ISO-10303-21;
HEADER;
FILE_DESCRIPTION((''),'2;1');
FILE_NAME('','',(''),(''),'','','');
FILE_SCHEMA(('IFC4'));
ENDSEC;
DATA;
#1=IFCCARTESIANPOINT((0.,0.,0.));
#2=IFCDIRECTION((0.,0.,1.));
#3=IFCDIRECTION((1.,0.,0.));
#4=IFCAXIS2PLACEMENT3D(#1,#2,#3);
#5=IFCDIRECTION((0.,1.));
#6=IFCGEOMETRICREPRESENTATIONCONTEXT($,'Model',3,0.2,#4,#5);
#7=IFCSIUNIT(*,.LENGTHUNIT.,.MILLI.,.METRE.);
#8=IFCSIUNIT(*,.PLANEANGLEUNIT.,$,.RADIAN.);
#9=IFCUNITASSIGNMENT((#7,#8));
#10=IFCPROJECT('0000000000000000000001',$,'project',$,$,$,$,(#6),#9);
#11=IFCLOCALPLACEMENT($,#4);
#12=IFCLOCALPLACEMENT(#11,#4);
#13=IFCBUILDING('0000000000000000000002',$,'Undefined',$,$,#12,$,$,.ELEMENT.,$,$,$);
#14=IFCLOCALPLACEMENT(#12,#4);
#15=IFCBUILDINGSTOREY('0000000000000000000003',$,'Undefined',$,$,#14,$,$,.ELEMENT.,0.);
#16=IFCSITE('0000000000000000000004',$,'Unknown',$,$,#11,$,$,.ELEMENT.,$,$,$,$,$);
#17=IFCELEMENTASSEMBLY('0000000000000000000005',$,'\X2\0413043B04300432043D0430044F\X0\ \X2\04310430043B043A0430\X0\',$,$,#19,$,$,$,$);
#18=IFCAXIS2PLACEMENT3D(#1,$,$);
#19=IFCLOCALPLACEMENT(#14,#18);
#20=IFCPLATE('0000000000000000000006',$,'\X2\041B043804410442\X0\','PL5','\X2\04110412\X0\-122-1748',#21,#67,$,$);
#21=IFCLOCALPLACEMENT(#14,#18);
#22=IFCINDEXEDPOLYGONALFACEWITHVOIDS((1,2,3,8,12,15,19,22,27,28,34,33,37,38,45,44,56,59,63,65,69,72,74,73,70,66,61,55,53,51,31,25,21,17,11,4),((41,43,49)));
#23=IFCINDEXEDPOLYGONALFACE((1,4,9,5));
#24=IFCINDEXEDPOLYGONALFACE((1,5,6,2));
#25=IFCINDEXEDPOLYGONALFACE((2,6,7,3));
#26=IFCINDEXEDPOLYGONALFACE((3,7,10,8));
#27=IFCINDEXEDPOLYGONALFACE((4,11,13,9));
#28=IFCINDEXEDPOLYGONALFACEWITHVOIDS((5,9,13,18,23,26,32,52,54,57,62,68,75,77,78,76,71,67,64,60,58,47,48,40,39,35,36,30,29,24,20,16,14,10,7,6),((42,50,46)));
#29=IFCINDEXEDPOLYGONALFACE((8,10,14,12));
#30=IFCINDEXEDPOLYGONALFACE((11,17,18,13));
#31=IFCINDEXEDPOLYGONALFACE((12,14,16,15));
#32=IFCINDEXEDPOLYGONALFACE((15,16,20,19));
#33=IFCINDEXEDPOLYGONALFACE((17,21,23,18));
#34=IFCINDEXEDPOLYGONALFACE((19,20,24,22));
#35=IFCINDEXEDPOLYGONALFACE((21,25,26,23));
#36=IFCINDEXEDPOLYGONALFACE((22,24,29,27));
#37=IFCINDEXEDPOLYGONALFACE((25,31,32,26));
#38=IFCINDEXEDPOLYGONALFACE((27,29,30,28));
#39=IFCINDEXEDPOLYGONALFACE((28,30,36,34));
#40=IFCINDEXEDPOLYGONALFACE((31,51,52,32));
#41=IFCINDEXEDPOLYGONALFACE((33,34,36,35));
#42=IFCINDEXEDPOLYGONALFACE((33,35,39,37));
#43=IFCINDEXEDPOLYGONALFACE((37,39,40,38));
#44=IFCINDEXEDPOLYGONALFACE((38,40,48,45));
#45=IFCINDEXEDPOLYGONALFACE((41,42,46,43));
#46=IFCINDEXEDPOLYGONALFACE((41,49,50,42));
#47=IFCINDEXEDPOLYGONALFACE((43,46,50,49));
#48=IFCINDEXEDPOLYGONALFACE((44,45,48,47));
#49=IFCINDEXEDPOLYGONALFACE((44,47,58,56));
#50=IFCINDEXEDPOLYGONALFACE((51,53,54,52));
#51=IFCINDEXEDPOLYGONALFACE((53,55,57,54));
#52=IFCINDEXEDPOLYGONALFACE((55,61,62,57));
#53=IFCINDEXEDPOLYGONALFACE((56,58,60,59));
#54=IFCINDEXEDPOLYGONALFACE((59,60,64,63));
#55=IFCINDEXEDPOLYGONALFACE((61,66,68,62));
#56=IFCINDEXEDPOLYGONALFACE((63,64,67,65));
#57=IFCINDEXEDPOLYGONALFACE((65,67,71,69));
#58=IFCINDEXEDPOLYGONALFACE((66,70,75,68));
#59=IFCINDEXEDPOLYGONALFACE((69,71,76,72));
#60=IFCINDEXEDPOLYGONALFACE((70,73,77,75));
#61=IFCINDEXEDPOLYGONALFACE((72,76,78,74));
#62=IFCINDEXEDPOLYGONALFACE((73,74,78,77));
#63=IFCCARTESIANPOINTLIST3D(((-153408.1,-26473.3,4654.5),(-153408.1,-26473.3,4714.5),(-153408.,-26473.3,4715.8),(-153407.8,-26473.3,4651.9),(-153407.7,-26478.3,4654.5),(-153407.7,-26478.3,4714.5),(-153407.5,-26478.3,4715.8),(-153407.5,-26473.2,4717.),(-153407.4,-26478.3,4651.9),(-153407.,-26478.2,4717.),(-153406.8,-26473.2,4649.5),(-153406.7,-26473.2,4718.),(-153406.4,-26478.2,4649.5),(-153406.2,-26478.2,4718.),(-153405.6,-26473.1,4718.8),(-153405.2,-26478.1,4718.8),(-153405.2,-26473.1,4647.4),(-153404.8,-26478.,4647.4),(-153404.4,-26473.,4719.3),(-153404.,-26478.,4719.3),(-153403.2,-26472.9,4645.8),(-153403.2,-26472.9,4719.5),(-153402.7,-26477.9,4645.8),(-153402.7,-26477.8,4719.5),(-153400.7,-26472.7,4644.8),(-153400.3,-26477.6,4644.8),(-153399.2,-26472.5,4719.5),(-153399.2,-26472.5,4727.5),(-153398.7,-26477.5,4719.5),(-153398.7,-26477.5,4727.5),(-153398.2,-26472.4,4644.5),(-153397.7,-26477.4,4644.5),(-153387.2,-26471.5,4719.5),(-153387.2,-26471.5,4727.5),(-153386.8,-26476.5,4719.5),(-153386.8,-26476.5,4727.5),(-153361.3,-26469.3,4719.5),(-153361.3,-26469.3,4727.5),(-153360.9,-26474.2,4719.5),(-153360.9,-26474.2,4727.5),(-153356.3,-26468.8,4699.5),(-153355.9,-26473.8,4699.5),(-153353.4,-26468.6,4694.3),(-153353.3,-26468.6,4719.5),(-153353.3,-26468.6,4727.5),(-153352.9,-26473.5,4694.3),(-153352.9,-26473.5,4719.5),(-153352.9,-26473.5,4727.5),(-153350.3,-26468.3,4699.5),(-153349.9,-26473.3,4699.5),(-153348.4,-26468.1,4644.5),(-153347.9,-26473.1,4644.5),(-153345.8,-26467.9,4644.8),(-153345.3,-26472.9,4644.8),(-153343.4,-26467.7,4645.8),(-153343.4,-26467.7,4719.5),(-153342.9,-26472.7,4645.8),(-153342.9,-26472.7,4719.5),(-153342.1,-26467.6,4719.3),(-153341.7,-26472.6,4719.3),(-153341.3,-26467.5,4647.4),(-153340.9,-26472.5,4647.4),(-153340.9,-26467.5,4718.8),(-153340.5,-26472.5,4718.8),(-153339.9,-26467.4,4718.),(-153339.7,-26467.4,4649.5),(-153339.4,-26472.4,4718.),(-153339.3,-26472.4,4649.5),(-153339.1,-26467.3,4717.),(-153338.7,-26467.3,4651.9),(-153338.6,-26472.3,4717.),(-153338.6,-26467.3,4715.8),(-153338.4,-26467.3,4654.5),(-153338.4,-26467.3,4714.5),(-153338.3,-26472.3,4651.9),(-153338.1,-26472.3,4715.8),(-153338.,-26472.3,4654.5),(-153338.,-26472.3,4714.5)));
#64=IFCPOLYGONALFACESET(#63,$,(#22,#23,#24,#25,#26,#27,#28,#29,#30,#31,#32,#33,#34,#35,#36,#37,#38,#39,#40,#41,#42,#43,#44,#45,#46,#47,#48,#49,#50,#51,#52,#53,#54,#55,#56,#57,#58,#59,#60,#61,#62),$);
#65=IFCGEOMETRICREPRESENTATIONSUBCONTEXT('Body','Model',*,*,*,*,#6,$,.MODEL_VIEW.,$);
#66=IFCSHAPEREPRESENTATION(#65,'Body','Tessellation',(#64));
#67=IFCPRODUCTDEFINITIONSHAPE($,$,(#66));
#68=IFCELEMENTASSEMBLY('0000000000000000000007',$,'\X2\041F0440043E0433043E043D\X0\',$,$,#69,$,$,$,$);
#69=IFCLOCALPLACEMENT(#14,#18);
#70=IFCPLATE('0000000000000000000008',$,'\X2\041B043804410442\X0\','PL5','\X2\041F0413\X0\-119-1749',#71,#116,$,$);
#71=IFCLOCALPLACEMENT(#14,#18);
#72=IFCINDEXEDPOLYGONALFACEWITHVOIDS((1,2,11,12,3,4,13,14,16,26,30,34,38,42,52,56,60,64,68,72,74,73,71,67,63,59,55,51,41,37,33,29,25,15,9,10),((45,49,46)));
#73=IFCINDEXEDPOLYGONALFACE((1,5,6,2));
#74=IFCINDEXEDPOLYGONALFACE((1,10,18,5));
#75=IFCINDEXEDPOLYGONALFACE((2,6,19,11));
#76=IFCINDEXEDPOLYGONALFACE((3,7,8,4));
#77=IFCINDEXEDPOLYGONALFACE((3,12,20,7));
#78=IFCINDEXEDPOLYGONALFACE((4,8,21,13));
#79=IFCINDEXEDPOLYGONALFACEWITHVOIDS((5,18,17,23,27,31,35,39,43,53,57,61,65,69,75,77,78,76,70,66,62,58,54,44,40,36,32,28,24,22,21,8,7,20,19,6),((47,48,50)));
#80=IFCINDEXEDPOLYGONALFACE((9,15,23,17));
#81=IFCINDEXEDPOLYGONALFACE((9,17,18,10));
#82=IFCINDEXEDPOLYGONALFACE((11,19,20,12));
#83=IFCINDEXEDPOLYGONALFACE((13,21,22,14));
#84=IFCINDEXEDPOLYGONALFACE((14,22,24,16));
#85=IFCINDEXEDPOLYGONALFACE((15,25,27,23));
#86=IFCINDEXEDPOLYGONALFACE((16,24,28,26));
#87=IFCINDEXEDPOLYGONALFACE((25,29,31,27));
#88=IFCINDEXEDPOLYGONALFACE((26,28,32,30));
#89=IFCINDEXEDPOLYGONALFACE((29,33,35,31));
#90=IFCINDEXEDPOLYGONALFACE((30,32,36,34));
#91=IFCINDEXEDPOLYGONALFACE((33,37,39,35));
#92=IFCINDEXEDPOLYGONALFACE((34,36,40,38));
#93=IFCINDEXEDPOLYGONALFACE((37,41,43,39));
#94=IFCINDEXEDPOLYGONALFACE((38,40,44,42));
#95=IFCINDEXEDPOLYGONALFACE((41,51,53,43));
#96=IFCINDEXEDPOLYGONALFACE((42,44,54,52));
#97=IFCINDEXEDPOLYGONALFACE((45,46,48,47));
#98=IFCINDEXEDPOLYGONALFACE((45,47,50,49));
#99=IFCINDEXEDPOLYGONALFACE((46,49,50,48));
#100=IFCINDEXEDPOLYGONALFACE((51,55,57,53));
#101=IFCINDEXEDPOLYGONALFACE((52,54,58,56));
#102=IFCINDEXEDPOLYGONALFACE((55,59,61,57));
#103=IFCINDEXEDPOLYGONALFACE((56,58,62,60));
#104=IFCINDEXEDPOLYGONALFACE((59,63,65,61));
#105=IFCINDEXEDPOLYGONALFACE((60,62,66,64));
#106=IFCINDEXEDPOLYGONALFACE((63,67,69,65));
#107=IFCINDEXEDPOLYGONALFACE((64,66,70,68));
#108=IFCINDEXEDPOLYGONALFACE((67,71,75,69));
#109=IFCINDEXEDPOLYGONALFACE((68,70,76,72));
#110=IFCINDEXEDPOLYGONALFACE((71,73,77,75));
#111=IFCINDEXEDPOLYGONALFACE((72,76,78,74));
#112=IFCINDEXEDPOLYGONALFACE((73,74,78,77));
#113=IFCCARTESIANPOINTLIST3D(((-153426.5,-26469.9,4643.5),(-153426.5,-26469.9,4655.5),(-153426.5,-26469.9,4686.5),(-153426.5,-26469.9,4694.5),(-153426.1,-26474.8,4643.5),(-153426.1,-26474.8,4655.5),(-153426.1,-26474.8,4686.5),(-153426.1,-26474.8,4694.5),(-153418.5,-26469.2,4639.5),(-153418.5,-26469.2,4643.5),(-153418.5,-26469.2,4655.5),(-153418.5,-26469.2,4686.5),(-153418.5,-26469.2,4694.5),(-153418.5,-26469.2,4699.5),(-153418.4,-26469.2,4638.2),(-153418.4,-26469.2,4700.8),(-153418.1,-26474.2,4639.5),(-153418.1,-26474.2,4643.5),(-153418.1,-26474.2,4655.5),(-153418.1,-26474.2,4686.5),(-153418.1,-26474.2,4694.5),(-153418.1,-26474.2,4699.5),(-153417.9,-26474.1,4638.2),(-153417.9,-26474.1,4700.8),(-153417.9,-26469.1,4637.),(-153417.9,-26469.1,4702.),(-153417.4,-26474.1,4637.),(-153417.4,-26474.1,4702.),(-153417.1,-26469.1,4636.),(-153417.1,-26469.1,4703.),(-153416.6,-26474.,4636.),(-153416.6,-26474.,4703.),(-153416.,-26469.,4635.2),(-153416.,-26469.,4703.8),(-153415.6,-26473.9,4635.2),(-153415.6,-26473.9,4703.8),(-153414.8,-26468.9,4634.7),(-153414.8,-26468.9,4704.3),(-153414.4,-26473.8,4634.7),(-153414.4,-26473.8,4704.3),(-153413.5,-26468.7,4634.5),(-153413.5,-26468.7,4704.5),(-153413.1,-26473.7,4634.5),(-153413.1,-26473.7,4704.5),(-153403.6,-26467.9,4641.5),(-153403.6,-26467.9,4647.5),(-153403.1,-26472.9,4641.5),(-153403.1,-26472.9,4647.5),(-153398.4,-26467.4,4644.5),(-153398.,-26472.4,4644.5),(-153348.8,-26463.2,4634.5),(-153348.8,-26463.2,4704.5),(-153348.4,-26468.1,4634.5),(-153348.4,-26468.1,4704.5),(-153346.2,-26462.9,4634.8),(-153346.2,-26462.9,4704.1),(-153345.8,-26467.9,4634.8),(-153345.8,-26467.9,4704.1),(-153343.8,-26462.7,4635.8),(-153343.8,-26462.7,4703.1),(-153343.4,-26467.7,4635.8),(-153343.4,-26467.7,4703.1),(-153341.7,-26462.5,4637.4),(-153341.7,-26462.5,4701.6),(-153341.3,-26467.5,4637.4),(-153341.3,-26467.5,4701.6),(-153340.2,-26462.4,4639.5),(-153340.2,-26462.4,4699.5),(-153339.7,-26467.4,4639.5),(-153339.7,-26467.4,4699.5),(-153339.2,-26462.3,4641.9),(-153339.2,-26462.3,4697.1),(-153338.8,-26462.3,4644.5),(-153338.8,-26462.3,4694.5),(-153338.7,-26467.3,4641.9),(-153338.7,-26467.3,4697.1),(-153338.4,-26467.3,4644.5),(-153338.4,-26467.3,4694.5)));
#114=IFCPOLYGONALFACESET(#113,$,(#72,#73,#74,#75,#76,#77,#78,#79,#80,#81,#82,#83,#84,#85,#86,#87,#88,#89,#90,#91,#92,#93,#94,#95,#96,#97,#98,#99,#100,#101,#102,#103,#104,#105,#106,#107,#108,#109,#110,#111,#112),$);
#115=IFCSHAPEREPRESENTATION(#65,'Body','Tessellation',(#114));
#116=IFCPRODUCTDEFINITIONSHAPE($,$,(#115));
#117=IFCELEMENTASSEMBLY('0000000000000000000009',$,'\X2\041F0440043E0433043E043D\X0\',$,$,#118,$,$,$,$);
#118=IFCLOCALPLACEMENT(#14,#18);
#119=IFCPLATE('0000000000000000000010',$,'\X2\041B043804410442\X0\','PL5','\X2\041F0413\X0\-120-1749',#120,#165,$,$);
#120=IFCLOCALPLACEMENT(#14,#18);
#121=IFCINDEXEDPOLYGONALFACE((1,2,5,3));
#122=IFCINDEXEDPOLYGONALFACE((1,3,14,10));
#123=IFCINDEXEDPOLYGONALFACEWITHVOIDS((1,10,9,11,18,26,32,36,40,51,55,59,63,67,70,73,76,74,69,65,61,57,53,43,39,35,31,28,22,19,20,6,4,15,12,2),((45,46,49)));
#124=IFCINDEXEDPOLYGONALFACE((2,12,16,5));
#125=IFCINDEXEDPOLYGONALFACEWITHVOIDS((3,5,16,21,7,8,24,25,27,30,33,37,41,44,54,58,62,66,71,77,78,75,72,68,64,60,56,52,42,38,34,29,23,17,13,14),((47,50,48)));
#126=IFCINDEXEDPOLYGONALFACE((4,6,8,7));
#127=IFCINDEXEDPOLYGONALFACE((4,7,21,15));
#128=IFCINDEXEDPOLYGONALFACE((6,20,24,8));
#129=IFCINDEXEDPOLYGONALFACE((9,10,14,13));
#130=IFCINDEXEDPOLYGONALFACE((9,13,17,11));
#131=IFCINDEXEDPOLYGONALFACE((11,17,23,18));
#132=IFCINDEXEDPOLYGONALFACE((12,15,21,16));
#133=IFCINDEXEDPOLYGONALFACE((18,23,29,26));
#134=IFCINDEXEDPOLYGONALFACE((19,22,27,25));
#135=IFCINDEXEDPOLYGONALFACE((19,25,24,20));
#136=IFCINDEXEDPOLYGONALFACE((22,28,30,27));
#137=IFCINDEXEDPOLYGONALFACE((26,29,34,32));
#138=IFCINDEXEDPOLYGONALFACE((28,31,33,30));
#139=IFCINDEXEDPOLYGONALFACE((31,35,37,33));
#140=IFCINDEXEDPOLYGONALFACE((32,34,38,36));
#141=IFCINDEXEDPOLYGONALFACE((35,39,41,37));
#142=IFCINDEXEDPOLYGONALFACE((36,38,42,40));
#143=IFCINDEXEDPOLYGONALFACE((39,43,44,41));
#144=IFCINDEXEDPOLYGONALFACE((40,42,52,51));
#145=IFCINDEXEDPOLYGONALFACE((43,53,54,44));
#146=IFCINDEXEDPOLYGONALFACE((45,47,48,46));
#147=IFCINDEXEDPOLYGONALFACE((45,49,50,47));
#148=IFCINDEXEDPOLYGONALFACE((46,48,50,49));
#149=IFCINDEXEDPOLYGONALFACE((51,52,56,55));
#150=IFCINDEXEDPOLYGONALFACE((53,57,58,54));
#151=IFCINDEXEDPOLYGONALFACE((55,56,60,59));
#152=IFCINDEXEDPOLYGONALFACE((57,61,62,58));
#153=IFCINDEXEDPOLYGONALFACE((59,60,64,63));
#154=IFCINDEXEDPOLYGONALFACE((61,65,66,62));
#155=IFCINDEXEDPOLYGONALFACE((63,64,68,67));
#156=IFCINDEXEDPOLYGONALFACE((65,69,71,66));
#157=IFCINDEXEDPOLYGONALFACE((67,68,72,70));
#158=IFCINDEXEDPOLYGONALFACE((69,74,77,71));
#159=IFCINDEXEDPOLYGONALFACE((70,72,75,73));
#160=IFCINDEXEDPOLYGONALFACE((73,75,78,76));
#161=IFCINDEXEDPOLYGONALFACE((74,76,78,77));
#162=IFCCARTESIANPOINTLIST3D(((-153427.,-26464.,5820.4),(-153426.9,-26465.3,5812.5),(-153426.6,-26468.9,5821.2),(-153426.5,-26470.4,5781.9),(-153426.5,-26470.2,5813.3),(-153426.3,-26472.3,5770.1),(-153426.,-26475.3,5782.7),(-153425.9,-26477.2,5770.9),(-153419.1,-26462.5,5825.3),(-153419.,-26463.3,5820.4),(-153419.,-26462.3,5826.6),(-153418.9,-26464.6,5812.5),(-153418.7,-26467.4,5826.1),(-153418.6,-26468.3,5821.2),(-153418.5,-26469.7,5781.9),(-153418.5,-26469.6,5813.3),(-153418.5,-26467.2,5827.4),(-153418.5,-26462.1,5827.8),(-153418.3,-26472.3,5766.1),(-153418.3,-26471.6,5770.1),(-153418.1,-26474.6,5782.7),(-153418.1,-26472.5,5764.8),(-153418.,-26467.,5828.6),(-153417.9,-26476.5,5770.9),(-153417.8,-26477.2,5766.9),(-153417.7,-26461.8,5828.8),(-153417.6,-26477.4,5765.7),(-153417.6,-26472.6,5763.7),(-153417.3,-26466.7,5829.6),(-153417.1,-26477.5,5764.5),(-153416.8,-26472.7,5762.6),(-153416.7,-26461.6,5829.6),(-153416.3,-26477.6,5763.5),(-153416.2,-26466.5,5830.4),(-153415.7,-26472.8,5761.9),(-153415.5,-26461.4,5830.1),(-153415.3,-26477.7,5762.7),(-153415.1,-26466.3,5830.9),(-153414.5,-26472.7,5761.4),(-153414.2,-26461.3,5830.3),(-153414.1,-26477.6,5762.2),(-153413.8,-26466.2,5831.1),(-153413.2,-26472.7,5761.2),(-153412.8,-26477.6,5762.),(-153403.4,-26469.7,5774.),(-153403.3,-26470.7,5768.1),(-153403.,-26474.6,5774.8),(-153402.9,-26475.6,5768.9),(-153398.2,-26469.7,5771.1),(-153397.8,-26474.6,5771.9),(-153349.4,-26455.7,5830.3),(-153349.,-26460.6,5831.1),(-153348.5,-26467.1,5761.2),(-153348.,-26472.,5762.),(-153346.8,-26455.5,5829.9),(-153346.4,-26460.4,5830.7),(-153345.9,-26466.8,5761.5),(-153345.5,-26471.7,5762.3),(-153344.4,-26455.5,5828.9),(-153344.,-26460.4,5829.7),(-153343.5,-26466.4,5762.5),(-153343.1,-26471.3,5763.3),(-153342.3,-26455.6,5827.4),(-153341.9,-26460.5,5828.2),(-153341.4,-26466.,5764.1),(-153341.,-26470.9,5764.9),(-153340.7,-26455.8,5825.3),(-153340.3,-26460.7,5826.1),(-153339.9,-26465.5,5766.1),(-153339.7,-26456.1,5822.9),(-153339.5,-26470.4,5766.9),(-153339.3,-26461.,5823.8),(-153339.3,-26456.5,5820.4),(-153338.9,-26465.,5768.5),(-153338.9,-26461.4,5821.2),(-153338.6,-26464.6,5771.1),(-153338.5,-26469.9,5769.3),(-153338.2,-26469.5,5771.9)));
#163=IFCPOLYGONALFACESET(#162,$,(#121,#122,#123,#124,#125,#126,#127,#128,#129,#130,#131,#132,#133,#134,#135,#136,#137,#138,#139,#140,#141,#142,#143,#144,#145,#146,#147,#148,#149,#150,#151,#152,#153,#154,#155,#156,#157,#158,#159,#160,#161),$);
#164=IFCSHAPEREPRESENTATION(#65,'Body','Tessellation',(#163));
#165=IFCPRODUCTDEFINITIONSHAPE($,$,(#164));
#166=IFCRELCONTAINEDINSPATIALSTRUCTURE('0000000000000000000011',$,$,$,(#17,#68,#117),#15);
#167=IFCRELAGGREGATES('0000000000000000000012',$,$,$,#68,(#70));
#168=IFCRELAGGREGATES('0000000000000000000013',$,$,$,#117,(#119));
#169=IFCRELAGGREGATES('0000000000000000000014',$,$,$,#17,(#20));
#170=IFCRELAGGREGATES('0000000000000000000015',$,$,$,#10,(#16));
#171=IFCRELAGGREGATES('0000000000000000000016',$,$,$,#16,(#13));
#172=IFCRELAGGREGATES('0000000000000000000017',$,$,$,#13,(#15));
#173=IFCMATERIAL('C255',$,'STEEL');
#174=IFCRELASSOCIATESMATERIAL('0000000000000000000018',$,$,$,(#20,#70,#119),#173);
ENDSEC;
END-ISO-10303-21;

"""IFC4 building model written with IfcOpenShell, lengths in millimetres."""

from ifc_helpers import new_model, si_unit, direction, frame, origin_with_axes, place, context, subcontext, project, spatial, line, arc, indexed_curve, outline, extrude, material, element, aggregate, save


model = new_model("IFC4")

# Units and contexts
model_context = context("Model", 3, precision=0.2, world=origin_with_axes(), true_north=direction((0.0, 1.0)))
body_context = subcontext(model_context, "Body", "Model", "MODEL_VIEW")
ifc_project = project(units=[si_unit("LENGTHUNIT", "METRE", prefix="MILLI"), si_unit("PLANEANGLEUNIT", "RADIAN")], contexts=[model_context])

# Site, building, storey
site_placement = place(None, origin_with_axes())
site = spatial("IfcSite", under=ifc_project, at=site_placement, Name="Unknown", CompositionType="ELEMENT")
building_placement = place(site_placement, origin_with_axes())
building = spatial("IfcBuilding", under=site, at=building_placement, Name="Undefined", CompositionType="ELEMENT")
storey_placement = place(building_placement, origin_with_axes())
storey = spatial("IfcBuildingStorey", under=building, at=storey_placement, Name="Undefined", CompositionType="ELEMENT", Elevation=0.0)

# Shared definitions
ifc_material_1 = material(Name="C255", Category="STEEL")

# Element assembly, plate, voiding feature
assembly_1_placement = place(storey_placement, frame((-153222.7, -28270.2, 4779.5), z_axis=(-0.996286, -0.086101, -0.000024), x_axis=(-0.086101, 0.996286, 0.0)))
assembly_1 = element("IfcElementAssembly", 1, at=assembly_1_placement, inside=storey, Name="Главная балка")
plate_1_placement = place(assembly_1_placement, frame((1803.7, 135.0, -40.0), z_axis=(1.0, 0.000054, 0.000013), x_axis=(-0.000013, -0.000054, 1.0)))
plate_1 = element("IfcPlate", 2, at=plate_1_placement, material=ifc_material_1, Name="Лист", Description="PL5", ObjectType="БВ-122-1748", context=body_context, shape_type="SolidModel", body=[
    extrude(outline(indexed_curve([(0.0, 10.0), (2.9, 2.9), (10.0, 0.0), (60.0, 0.0), (67.1, 2.9), (70.0, 10.0), (70.0, 70.0), (68.5, 73.5), (65.0, 75.0), (61.0, 75.0), (61.0, 83.0), (49.0, 83.0), (49.0, 75.0), (23.0, 75.0), (23.0, 83.0), (15.0, 83.0), (15.0, 75.0), (5.0, 75.0), (1.5, 73.5), (0.0, 70.0)], segments=[arc(1, 2, 3), line(3, 4), arc(4, 5, 6), line(6, 7), arc(7, 8, 9), line(9, 10, 11, 12, 13, 14, 15, 16, 17, 18), arc(18, 19, 20), line(20, 1)])), frame((0.0, 0.0, 2.5), z_axis=(0.0, 0.0, 1.0), x_axis=(1.0, 0.0, 0.0)), (0.0, 0.0, -1.0), 5.0),
])
voiding_feature_1_placement = place(plate_1_placement, frame((15.0, 55.0, 10.0), z_axis=(0.007997, -0.999968, -0.000026), x_axis=(0.0, 0.000026, -1.0)))
element("IfcVoidingFeature", 3, at=voiding_feature_1_placement, cuts=plate_1, Name="Балка", ObjectType="(?)", PredefinedType="HOLE", context=body_context, shape_type="SolidModel", body=[
    extrude(outline(indexed_curve([(0.0, -3.0), (5.2, 0.0), (0.0, 3.0)], segments=[line(1, 2, 3, 1)])), frame((0.0, 0.0, 0.0), z_axis=(-1.0, 0.0, 0.0), x_axis=(0.0, 0.0, 1.0)), (0.0, 0.0, -1.0), 20.0),
])

# Element assembly, plate, voiding feature
assembly_2_placement = place(storey_placement, frame((-153458.2, -26475.1, 3063.5), z_axis=(0.086114, -0.996285, 0.0), x_axis=(0.0, 0.0, 1.0)))
assembly_2 = element("IfcElementAssembly", 4, at=assembly_2_placement, inside=storey, Name="Прогон")
plate_2_placement = place(assembly_2_placement, frame((1641.0, -120.0, 0.0), z_axis=(0.0, -0.000057, -1.0), x_axis=(-1.0, 0.000024, 0.0)))
plate_2 = element("IfcPlate", 5, at=plate_2_placement, material=ifc_material_1, Name="Лист", Description="PL5", ObjectType="ПГ-119-1749", context=body_context, shape_type="SolidModel", body=[
    extrude(outline(indexed_curve([(0.0, 10.0), (2.9, 2.9), (10.0, 0.0), (60.0, 0.0), (67.1, 2.9), (70.0, 10.0), (70.0, 75.0), (68.5, 78.5), (65.0, 80.0), (61.0, 80.0), (61.0, 88.0), (49.0, 88.0), (49.0, 80.0), (18.0, 80.0), (18.0, 88.0), (10.0, 88.0), (10.0, 80.0), (5.0, 80.0), (1.5, 78.5), (0.0, 75.0)], segments=[arc(1, 2, 3), line(3, 4), arc(4, 5, 6), line(6, 7), arc(7, 8, 9), line(9, 10, 11, 12, 13, 14, 15, 16, 17, 18), arc(18, 19, 20), line(20, 1)])), frame((0.0, 0.0, 2.5), z_axis=(0.0, 0.0, 1.0), x_axis=(1.0, 0.0, 0.0)), (0.0, 0.0, -1.0), 5.0),
])
voiding_feature_2_placement = place(plate_2_placement, frame((60.0, 65.0, 6.0), z_axis=(-0.000054, -1.0, 0.000034), x_axis=(0.0, -0.000034, -1.0)))
element("IfcVoidingFeature", 6, at=voiding_feature_2_placement, cuts=plate_2, Name="Балка", ObjectType="(?)", PredefinedType="HOLE", context=body_context, shape_type="SolidModel", body=[
    extrude(outline(indexed_curve([(0.0, -3.0), (5.2, 0.0), (0.0, 3.0)], segments=[line(1, 2, 3, 1)])), frame((0.0, 0.0, 0.0), z_axis=(-1.0, 0.0, 0.0), x_axis=(0.0, 0.0, 1.0)), (0.0, 0.0, -1.0), 12.0),
])
aggregate(assembly_2, [plate_2])

# Element assembly, plate, voiding feature
assembly_3_placement = place(storey_placement, frame((-153458.2, -26475.1, 4779.5), z_axis=(0.086114, -0.996285, 0.0), x_axis=(0.0, 0.0, 1.0)))
assembly_3 = element("IfcElementAssembly", 7, at=assembly_3_placement, inside=storey, Name="Прогон")
plate_3_placement = place(assembly_3_placement, frame((1051.2, -120.0, -7.5), z_axis=(-0.162881, -0.000054, -0.986646), x_axis=(-0.986646, 0.000078, 0.162881)))
plate_3 = element("IfcPlate", 8, at=plate_3_placement, material=ifc_material_1, Name="Лист", Description="PL5", ObjectType="ПГ-120-1749", context=body_context, shape_type="SolidModel", body=[
    extrude(outline(indexed_curve([(0.0, 10.0), (2.9, 2.9), (10.0, 0.0), (60.0, 0.0), (67.1, 2.9), (70.0, 10.0), (70.0, 75.0), (68.5, 78.5), (65.0, 80.0), (61.0, 80.0), (61.0, 88.0), (49.0, 88.0), (49.0, 80.0), (18.0, 80.0), (18.0, 88.0), (10.0, 88.0), (10.0, 80.0), (5.0, 80.0), (1.5, 78.5), (0.0, 75.0)], segments=[arc(1, 2, 3), line(3, 4), arc(4, 5, 6), line(6, 7), arc(7, 8, 9), line(9, 10, 11, 12, 13, 14, 15, 16, 17, 18), arc(18, 19, 20), line(20, 1)])), frame((0.0, 0.0, 2.5), z_axis=(0.0, 0.0, 1.0), x_axis=(1.0, 0.0, 0.0)), (0.0, 0.0, -1.0), 5.0),
])
voiding_feature_3_placement = place(plate_3_placement, frame((60.0, 65.0, 6.0), z_axis=(-0.000054, -1.0, 0.000034), x_axis=(0.0, -0.000034, -1.0)))
element("IfcVoidingFeature", 9, at=voiding_feature_3_placement, cuts=plate_3, Name="Балка", ObjectType="(?)", PredefinedType="HOLE", context=body_context, shape_type="SolidModel", body=[
    extrude(outline(indexed_curve([(0.0, -3.0), (5.2, 0.0), (0.0, 3.0)], segments=[line(1, 2, 3, 1)])), frame((0.0, 0.0, 0.0), z_axis=(-1.0, 0.0, 0.0), x_axis=(0.0, 0.0, 1.0)), (0.0, 0.0, -1.0), 12.0),
])

aggregate(assembly_3, [plate_3])
aggregate(assembly_1, [plate_1])

save(model, "model.ifc")
